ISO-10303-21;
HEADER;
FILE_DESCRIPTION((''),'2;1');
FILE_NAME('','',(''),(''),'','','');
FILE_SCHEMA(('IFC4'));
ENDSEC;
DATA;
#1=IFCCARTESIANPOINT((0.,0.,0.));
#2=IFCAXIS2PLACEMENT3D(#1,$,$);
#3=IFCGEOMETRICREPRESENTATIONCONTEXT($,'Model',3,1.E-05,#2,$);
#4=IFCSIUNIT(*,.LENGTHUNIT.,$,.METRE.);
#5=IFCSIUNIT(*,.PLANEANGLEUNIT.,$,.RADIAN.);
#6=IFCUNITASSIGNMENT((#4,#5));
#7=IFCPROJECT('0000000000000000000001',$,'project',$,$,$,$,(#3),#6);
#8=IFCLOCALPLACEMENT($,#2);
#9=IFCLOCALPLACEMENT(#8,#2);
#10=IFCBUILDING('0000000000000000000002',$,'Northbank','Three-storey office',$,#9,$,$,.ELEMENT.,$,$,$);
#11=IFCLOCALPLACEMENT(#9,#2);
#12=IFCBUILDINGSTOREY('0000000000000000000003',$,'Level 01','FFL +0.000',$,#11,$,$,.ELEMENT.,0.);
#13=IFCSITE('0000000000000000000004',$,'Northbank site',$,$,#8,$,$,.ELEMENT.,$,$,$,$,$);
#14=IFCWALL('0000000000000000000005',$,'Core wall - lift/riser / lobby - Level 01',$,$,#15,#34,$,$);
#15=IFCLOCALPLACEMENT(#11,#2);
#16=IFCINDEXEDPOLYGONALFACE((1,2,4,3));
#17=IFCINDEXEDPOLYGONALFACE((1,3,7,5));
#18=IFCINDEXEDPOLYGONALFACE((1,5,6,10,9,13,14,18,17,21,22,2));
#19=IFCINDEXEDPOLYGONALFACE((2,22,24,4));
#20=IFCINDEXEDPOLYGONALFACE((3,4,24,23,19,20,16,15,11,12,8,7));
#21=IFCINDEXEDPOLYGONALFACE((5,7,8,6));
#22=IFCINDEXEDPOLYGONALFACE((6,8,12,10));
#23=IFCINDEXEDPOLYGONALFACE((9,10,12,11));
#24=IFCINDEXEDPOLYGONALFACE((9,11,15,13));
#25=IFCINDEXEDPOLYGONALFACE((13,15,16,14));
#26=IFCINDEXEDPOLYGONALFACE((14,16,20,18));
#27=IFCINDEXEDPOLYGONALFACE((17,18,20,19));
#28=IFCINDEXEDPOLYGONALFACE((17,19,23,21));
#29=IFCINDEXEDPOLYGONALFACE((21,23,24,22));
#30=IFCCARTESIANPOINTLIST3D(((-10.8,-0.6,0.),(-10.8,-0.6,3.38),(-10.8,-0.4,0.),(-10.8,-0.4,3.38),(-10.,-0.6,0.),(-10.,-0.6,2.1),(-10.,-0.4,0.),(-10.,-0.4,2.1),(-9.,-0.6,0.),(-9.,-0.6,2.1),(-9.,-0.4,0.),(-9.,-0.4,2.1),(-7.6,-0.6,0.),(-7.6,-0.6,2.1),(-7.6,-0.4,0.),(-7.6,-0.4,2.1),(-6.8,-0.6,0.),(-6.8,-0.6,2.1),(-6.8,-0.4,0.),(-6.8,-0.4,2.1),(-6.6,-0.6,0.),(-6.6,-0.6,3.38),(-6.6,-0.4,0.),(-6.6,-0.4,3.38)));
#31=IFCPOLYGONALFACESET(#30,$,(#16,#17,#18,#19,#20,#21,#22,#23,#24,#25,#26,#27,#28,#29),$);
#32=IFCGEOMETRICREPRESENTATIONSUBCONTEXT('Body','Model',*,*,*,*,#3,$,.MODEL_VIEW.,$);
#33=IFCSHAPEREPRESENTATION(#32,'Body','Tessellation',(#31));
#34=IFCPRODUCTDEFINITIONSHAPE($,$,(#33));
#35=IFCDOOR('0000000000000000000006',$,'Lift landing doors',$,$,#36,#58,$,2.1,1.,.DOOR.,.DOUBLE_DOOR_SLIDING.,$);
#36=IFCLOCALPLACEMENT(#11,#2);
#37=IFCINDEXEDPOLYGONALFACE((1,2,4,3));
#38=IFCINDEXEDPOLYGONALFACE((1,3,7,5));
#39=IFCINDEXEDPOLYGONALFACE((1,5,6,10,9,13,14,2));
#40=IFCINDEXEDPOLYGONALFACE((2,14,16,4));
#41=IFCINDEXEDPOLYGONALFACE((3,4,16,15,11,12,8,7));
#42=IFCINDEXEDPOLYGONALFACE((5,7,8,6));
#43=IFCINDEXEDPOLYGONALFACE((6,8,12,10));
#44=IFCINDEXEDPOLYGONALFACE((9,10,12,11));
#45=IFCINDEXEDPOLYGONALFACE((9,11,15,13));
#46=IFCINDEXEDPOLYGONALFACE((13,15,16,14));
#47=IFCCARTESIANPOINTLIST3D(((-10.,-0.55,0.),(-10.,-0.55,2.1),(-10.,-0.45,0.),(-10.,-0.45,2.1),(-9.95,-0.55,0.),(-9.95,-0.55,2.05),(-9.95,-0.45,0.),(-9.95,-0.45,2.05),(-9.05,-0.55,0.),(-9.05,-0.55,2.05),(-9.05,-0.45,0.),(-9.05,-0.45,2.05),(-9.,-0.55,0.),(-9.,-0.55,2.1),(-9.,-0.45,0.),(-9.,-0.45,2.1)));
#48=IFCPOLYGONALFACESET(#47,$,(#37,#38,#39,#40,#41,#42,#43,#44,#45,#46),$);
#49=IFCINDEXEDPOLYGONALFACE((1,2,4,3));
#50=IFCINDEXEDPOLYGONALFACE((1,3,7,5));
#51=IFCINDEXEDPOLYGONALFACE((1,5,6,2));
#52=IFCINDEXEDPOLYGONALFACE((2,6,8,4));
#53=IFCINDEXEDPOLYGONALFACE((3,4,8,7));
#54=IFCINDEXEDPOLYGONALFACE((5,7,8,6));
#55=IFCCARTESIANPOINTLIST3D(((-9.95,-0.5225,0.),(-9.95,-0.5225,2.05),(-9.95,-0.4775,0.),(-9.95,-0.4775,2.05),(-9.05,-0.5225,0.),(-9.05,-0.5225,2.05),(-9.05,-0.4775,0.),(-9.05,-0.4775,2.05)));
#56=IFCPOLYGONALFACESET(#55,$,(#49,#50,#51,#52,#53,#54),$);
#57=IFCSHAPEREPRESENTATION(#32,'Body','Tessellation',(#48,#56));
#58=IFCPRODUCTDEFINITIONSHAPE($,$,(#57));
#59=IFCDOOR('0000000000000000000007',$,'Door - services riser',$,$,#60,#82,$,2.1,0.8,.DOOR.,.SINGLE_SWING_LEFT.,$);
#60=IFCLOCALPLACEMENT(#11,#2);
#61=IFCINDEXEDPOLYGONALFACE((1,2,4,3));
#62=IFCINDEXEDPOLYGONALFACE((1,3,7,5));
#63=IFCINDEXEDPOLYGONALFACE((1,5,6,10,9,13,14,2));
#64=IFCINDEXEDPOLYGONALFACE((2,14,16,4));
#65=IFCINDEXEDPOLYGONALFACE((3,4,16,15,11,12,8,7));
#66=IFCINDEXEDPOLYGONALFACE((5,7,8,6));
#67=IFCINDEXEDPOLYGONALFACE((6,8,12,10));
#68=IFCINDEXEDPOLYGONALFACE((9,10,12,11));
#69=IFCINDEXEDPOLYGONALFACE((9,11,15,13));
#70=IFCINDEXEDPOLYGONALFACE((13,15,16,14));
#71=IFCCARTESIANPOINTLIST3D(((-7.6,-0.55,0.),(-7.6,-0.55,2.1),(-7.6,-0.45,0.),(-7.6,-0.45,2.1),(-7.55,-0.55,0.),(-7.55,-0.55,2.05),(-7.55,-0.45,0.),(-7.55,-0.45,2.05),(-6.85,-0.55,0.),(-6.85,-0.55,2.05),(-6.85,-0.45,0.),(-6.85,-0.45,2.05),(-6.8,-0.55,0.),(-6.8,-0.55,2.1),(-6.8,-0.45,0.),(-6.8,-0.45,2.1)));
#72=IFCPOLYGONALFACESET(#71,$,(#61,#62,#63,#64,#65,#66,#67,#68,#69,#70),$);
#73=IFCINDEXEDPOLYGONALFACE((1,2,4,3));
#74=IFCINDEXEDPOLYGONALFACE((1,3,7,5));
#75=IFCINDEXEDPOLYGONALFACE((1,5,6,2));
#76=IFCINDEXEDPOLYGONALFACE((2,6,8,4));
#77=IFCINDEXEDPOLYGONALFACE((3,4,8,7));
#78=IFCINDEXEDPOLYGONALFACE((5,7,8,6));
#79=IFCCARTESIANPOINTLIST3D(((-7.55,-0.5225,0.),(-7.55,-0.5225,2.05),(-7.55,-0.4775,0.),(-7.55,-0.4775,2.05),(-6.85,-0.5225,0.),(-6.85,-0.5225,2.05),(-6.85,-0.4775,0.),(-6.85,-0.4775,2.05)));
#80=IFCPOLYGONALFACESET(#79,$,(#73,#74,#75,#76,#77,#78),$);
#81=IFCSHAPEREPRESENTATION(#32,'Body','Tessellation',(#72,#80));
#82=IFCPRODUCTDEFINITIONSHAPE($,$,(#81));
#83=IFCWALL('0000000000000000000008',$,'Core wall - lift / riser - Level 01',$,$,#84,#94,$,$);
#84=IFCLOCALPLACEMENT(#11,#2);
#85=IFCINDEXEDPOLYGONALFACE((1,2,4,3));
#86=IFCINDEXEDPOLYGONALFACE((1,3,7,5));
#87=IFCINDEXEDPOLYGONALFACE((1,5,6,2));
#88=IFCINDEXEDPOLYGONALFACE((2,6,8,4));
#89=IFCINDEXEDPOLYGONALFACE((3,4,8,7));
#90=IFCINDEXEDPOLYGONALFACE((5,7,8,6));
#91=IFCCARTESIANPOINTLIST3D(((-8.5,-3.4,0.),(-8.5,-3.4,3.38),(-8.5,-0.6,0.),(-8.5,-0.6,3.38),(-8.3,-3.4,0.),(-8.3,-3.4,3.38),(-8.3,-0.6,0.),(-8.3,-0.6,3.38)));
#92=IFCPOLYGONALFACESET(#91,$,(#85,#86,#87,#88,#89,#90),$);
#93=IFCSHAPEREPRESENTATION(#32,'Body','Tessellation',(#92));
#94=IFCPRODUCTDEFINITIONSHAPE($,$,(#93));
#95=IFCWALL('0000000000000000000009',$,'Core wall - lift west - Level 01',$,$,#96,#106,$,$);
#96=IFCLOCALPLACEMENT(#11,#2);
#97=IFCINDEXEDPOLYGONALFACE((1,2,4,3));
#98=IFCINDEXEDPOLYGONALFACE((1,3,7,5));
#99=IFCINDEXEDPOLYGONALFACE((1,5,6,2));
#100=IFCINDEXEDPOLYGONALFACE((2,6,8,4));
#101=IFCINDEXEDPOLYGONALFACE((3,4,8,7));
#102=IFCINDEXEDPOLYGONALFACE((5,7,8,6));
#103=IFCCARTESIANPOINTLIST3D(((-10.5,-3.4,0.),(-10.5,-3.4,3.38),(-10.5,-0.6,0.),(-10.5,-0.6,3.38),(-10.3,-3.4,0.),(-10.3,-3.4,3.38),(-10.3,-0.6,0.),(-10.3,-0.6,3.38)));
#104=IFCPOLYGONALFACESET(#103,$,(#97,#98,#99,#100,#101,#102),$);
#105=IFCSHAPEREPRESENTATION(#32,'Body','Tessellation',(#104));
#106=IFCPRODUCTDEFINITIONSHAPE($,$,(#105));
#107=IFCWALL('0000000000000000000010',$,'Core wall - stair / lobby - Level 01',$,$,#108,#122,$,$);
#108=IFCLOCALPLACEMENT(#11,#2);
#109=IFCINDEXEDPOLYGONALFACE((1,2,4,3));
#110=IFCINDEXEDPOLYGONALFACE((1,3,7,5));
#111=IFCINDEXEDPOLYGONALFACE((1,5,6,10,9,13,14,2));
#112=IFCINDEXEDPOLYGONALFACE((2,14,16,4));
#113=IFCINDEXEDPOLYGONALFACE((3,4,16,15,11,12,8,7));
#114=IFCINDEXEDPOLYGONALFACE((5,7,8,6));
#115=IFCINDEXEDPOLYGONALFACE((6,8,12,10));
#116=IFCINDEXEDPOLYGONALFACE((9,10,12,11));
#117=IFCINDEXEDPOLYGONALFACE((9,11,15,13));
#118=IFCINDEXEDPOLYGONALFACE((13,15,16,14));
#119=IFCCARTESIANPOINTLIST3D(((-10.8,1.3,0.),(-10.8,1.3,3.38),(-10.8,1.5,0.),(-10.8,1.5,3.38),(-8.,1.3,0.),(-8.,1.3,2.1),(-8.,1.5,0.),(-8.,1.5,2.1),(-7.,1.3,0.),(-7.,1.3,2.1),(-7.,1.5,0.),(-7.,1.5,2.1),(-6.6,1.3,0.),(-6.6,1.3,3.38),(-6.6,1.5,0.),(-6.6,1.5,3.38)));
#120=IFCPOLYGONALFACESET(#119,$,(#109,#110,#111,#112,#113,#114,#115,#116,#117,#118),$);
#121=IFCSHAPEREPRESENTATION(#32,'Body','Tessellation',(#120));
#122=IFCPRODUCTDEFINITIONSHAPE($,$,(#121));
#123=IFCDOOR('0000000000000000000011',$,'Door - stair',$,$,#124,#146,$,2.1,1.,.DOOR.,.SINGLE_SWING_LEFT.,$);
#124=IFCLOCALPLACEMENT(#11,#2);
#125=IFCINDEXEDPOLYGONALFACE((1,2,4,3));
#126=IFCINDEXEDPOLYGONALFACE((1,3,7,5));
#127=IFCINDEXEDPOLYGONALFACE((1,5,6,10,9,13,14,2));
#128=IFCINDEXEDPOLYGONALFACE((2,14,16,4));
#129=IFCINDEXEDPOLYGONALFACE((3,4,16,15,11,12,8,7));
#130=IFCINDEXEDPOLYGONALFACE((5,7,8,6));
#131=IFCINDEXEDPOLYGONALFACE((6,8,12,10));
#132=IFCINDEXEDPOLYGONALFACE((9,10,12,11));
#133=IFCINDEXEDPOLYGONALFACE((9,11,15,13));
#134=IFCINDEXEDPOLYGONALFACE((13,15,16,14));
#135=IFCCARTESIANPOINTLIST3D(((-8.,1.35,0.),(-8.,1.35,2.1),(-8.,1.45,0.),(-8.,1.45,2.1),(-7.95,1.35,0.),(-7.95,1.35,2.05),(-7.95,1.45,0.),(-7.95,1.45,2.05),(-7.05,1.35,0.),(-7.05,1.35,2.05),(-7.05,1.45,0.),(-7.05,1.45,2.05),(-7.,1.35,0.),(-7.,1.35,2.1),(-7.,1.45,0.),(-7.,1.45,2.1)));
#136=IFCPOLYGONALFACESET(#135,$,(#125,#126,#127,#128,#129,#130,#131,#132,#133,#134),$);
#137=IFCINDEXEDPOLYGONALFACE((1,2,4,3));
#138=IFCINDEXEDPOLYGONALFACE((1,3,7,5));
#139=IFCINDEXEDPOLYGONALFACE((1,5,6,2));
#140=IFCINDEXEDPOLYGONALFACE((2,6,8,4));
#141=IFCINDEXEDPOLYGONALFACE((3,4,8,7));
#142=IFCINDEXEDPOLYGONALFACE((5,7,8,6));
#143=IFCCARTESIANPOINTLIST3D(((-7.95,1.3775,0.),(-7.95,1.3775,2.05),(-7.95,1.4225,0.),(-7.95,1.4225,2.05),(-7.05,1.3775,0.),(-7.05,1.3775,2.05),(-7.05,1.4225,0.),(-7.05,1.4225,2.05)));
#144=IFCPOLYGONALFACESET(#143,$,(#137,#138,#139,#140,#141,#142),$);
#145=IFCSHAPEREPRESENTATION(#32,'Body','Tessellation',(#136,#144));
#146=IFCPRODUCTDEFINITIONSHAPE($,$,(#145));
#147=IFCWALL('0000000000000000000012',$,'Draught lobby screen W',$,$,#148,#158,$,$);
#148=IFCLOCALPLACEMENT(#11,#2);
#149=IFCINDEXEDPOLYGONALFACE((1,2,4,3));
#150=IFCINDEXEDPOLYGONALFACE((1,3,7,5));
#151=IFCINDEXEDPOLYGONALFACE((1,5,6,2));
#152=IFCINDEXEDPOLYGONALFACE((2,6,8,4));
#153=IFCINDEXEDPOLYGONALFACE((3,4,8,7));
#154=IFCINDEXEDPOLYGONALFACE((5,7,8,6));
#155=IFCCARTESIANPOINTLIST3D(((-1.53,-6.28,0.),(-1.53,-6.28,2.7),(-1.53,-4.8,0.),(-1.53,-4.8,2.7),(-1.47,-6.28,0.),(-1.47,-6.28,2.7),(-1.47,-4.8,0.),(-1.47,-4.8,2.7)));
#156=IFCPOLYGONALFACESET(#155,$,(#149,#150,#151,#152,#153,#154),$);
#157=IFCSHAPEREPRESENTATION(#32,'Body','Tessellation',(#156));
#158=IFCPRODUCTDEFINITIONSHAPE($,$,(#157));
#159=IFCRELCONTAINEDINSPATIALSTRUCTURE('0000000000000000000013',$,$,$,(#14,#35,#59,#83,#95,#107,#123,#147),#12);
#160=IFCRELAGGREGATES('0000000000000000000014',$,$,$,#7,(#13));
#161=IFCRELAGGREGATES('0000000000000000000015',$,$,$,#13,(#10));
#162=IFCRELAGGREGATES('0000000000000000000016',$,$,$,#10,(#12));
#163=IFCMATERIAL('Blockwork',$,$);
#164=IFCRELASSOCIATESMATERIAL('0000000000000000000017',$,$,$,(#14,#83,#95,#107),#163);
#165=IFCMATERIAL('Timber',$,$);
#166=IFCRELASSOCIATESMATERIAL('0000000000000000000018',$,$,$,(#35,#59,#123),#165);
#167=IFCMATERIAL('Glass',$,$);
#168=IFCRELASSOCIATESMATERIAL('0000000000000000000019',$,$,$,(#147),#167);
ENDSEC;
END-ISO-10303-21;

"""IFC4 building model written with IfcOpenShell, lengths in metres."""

from ifc_helpers import new_model, si_unit, frame, origin, place, context, subcontext, project, spatial, polyline, outline, extrude, material, element, fill, save


model = new_model("IFC4")

# Units and contexts
model_context = context("Model", 3, precision=1e-05, world=origin())
body_context = subcontext(model_context, "Body", "Model", "MODEL_VIEW")
ifc_project = project(units=[si_unit("LENGTHUNIT", "METRE"), si_unit("PLANEANGLEUNIT", "RADIAN")], contexts=[model_context])

# Site, building, storey
site_placement = place(None, origin())
site = spatial("IfcSite", under=ifc_project, at=site_placement, Name="Northbank site", CompositionType="ELEMENT")
building_placement = place(site_placement, origin())
building = spatial("IfcBuilding", under=site, at=building_placement, Name="Northbank", Description="Three-storey office", CompositionType="ELEMENT")
storey_placement = place(building_placement, origin())
storey = spatial("IfcBuildingStorey", under=building, at=storey_placement, Name="Level 01", Description="FFL +0.000", CompositionType="ELEMENT", Elevation=0.0)

# Shared definitions
ifc_material_1 = material(Name="Glass")

# Shared definitions
ifc_material_2 = material(Name="Blockwork")
ifc_material_3 = material(Name="Timber")

# Wall, openings, doors
wall_1_placement = place(storey_placement, origin())
wall_1 = element("IfcWall", 1, at=wall_1_placement, inside=storey, material=ifc_material_2, Name="Core wall - lift/riser / lobby - Level 01", context=body_context, shape_type="SweptSolid", body=[
    extrude(outline(polyline([(0.0, 0.0), (0.8, 0.0), (0.8, 2.1), (1.8, 2.1), (1.8, 0.0), (3.2, 0.0), (3.2, 2.1), (4.0, 2.1), (4.0, 0.0), (4.2, 0.0), (4.2, 3.38), (0.0, 3.38), (0.0, 0.0)])), frame((-10.8, -0.4, 0.0), z_axis=(0.0, -1.0, 0.0), x_axis=(1.0, 0.0, 0.0)), (0.0, 0.0, 1.0), 0.2),
])
opening_1_placement = place(storey_placement, origin())
opening_1 = element("IfcOpeningElement", 2, at=opening_1_placement, cuts=wall_1, PredefinedType="OPENING", context=body_context, shape_type="SweptSolid", body=[
    extrude(outline(polyline([(0.0, 0.0), (1.0, 0.0), (1.0, 2.1), (0.0, 2.1), (0.0, 0.0)])), frame((-10.0, -0.35, 0.0), z_axis=(0.0, -1.0, 0.0), x_axis=(1.0, 0.0, 0.0)), (0.0, 0.0, 1.0), 0.3),
])
opening_2_placement = place(storey_placement, origin())
opening_2 = element("IfcOpeningElement", 3, at=opening_2_placement, cuts=wall_1, PredefinedType="OPENING", context=body_context, shape_type="SweptSolid", body=[
    extrude(outline(polyline([(0.0, 0.0), (0.8, 0.0), (0.8, 2.1), (0.0, 2.1), (0.0, 0.0)])), frame((-7.6, -0.35, 0.0), z_axis=(0.0, -1.0, 0.0), x_axis=(1.0, 0.0, 0.0)), (0.0, 0.0, 1.0), 0.3),
])
door_1_placement = place(storey_placement, origin())
door_1 = element("IfcDoor", 4, at=door_1_placement, inside=storey, material=ifc_material_3, Name="Lift landing doors", OperationType="DOUBLE_DOOR_SLIDING", OverallHeight=2.1, OverallWidth=1.0, PredefinedType="DOOR", context=body_context, shape_type="SweptSolid", body=[
    extrude(outline(polyline([(0.0, 0.0), (0.05, 0.0), (0.05, 2.05), (0.95, 2.05), (0.95, 0.0), (1.0, 0.0), (1.0, 2.1), (0.0, 2.1), (0.0, 0.0)])), frame((-10.0, -0.45, 0.0), z_axis=(0.0, -1.0, 0.0), x_axis=(1.0, 0.0, 0.0)), (0.0, 0.0, 1.0), 0.1),
    extrude(outline(polyline([(0.0, 0.0), (0.9, 0.0), (0.9, 2.05), (0.0, 2.05), (0.0, 0.0)])), frame((-9.95, -0.4775, 0.0), z_axis=(0.0, -1.0, 0.0), x_axis=(1.0, 0.0, 0.0)), (0.0, 0.0, 1.0), 0.045),
])
fill(opening_1, door_1)
door_2_placement = place(storey_placement, origin())
door_2 = element("IfcDoor", 5, at=door_2_placement, inside=storey, material=ifc_material_3, Name="Door - services riser", OperationType="SINGLE_SWING_LEFT", OverallHeight=2.1, OverallWidth=0.8, PredefinedType="DOOR", context=body_context, shape_type="SweptSolid", body=[
    extrude(outline(polyline([(0.0, 0.0), (0.05, 0.0), (0.05, 2.05), (0.75, 2.05), (0.75, 0.0), (0.8, 0.0), (0.8, 2.1), (0.0, 2.1), (0.0, 0.0)])), frame((-7.6, -0.45, 0.0), z_axis=(0.0, -1.0, 0.0), x_axis=(1.0, 0.0, 0.0)), (0.0, 0.0, 1.0), 0.1),
    extrude(outline(polyline([(0.0, 0.0), (0.7, 0.0), (0.7, 2.05), (0.0, 2.05), (0.0, 0.0)])), frame((-7.55, -0.4775, 0.0), z_axis=(0.0, -1.0, 0.0), x_axis=(1.0, 0.0, 0.0)), (0.0, 0.0, 1.0), 0.045),
])
fill(opening_2, door_2)

# Walls
wall_2_placement = place(storey_placement, origin())
element("IfcWall", 6, at=wall_2_placement, inside=storey, material=ifc_material_2, Name="Core wall - lift / riser - Level 01", context=body_context, shape_type="SweptSolid", body=[
    extrude(outline(polyline([(0.0, 0.0), (2.8, 0.0), (2.8, 3.38), (0.0, 3.38), (0.0, 0.0)])), frame((-8.5, -3.4, 0.0), z_axis=(1.0, 0.0, 0.0), x_axis=(0.0, 1.0, 0.0)), (0.0, 0.0, 1.0), 0.2),
])
wall_3_placement = place(storey_placement, origin())
element("IfcWall", 7, at=wall_3_placement, inside=storey, material=ifc_material_2, Name="Core wall - lift west - Level 01", context=body_context, shape_type="SweptSolid", body=[
    extrude(outline(polyline([(0.0, 0.0), (2.8, 0.0), (2.8, 3.38), (0.0, 3.38), (0.0, 0.0)])), frame((-10.5, -3.4, 0.0), z_axis=(1.0, 0.0, 0.0), x_axis=(0.0, 1.0, 0.0)), (0.0, 0.0, 1.0), 0.2),
])

# Wall, opening, door
wall_4_placement = place(storey_placement, origin())
wall_4 = element("IfcWall", 8, at=wall_4_placement, inside=storey, material=ifc_material_2, Name="Core wall - stair / lobby - Level 01", context=body_context, shape_type="SweptSolid", body=[
    extrude(outline(polyline([(0.0, 0.0), (2.8, 0.0), (2.8, 2.1), (3.8, 2.1), (3.8, 0.0), (4.2, 0.0), (4.2, 3.38), (0.0, 3.38), (0.0, 0.0)])), frame((-10.8, 1.5, 0.0), z_axis=(0.0, -1.0, 0.0), x_axis=(1.0, 0.0, 0.0)), (0.0, 0.0, 1.0), 0.2),
])
opening_3_placement = place(storey_placement, origin())
opening_3 = element("IfcOpeningElement", 9, at=opening_3_placement, cuts=wall_4, PredefinedType="OPENING", context=body_context, shape_type="SweptSolid", body=[
    extrude(outline(polyline([(0.0, 0.0), (1.0, 0.0), (1.0, 2.1), (0.0, 2.1), (0.0, 0.0)])), frame((-8.0, 1.55, 0.0), z_axis=(0.0, -1.0, 0.0), x_axis=(1.0, 0.0, 0.0)), (0.0, 0.0, 1.0), 0.3),
])
door_3_placement = place(storey_placement, origin())
door_3 = element("IfcDoor", 10, at=door_3_placement, inside=storey, material=ifc_material_3, Name="Door - stair", OperationType="SINGLE_SWING_LEFT", OverallHeight=2.1, OverallWidth=1.0, PredefinedType="DOOR", context=body_context, shape_type="SweptSolid", body=[
    extrude(outline(polyline([(0.0, 0.0), (0.05, 0.0), (0.05, 2.05), (0.95, 2.05), (0.95, 0.0), (1.0, 0.0), (1.0, 2.1), (0.0, 2.1), (0.0, 0.0)])), frame((-8.0, 1.45, 0.0), z_axis=(0.0, -1.0, 0.0), x_axis=(1.0, 0.0, 0.0)), (0.0, 0.0, 1.0), 0.1),
    extrude(outline(polyline([(0.0, 0.0), (0.9, 0.0), (0.9, 2.05), (0.0, 2.05), (0.0, 0.0)])), frame((-7.95, 1.4225, 0.0), z_axis=(0.0, -1.0, 0.0), x_axis=(1.0, 0.0, 0.0)), (0.0, 0.0, 1.0), 0.045),
])
fill(opening_3, door_3)

# Wall
wall_5_placement = place(storey_placement, origin())
element("IfcWall", 11, at=wall_5_placement, inside=storey, material=ifc_material_1, Name="Draught lobby screen W", context=body_context, shape_type="SweptSolid", body=[
    extrude(outline(polyline([(0.0, 0.0), (1.48, 0.0), (1.48, 2.7), (0.0, 2.7), (0.0, 0.0)])), frame((-1.53, -6.28, 0.0), z_axis=(1.0, 0.0, 0.0), x_axis=(0.0, 1.0, 0.0)), (0.0, 0.0, 1.0), 0.06),
])

save(model, "model.ifc")
